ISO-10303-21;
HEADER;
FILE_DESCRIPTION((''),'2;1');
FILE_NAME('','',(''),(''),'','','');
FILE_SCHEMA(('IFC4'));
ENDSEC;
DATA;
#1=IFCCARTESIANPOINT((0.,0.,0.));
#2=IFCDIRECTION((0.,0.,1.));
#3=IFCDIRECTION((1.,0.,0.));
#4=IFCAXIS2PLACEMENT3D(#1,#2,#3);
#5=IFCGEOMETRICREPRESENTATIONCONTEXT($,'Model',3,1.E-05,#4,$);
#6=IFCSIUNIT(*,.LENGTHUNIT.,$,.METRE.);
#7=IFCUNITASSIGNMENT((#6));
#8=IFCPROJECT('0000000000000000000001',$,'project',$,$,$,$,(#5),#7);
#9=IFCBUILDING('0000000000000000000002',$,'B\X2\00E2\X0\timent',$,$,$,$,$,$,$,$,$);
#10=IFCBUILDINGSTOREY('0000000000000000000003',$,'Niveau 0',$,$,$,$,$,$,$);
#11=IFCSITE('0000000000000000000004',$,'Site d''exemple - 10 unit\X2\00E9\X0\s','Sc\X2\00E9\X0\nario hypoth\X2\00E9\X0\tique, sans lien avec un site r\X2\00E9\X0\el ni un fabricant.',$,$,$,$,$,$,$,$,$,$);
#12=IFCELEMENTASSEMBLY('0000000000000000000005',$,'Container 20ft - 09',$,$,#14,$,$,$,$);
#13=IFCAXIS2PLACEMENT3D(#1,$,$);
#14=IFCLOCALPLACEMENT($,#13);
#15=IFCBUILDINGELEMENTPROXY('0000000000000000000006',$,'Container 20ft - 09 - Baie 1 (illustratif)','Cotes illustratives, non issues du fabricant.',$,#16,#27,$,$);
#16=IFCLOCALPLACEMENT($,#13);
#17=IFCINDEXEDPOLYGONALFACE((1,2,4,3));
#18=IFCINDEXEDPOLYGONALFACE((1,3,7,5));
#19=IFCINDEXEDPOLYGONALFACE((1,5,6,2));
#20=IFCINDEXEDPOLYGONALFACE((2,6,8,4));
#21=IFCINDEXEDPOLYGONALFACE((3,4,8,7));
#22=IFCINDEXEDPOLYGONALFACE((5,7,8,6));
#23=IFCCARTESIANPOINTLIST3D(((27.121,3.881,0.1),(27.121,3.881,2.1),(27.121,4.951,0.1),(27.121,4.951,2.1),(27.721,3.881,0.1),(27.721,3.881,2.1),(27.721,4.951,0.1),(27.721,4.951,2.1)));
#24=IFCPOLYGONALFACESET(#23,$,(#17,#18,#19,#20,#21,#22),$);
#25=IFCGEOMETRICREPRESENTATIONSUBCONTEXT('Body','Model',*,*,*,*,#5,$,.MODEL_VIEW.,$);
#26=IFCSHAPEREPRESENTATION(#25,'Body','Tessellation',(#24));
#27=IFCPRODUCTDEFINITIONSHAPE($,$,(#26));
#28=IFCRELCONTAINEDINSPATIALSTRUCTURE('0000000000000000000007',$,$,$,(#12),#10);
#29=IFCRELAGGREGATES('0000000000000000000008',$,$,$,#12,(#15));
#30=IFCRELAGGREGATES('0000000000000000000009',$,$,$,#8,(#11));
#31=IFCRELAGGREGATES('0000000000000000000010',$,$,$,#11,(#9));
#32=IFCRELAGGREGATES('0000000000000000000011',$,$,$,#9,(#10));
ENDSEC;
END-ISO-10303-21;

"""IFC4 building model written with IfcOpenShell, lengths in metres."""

from ifc_helpers import new_model, si_unit, frame, origin_with_axes, place, context, subcontext, project, spatial, rectangle, extrude, element, aggregate, save


model = new_model("IFC4")

# Units and contexts
model_context = context("Model", 3, precision=1e-05, world=origin_with_axes())
body_context = subcontext(model_context, "Body", "Model", "MODEL_VIEW")
ifc_project = project(units=[si_unit("LENGTHUNIT", "METRE")], contexts=[model_context])

# Site, building, storey
site = spatial("IfcSite", under=ifc_project, Name="Site d'exemple - 10 unités", Description="Scénario hypothétique, sans lien avec un site réel ni un fabricant.")
building = spatial("IfcBuilding", under=site, Name="Bâtiment")
storey = spatial("IfcBuildingStorey", under=building, Name="Niveau 0")

# Element assembly
assembly_1 = element("IfcElementAssembly", 1, inside=storey, Name="Container 20ft - 09")

# Building element proxy
proxy_1_placement = place(None, frame((27.421, 4.416, 0.1), z_axis=(0.0, 0.0, 1.0), x_axis=(1.0, 0.0, 0.0)))
proxy_1 = element("IfcBuildingElementProxy", 2, at=proxy_1_placement, Name="Container 20ft - 09 - Baie 1 (illustratif)", Description="Cotes illustratives, non issues du fabricant.", context=body_context, shape_type="SweptSolid", body=[
    extrude(rectangle(XDim=0.6, YDim=1.07), origin_with_axes(), (0.0, 0.0, 1.0), 2.0),
])
aggregate(assembly_1, [proxy_1])

save(model, "model.ifc")
